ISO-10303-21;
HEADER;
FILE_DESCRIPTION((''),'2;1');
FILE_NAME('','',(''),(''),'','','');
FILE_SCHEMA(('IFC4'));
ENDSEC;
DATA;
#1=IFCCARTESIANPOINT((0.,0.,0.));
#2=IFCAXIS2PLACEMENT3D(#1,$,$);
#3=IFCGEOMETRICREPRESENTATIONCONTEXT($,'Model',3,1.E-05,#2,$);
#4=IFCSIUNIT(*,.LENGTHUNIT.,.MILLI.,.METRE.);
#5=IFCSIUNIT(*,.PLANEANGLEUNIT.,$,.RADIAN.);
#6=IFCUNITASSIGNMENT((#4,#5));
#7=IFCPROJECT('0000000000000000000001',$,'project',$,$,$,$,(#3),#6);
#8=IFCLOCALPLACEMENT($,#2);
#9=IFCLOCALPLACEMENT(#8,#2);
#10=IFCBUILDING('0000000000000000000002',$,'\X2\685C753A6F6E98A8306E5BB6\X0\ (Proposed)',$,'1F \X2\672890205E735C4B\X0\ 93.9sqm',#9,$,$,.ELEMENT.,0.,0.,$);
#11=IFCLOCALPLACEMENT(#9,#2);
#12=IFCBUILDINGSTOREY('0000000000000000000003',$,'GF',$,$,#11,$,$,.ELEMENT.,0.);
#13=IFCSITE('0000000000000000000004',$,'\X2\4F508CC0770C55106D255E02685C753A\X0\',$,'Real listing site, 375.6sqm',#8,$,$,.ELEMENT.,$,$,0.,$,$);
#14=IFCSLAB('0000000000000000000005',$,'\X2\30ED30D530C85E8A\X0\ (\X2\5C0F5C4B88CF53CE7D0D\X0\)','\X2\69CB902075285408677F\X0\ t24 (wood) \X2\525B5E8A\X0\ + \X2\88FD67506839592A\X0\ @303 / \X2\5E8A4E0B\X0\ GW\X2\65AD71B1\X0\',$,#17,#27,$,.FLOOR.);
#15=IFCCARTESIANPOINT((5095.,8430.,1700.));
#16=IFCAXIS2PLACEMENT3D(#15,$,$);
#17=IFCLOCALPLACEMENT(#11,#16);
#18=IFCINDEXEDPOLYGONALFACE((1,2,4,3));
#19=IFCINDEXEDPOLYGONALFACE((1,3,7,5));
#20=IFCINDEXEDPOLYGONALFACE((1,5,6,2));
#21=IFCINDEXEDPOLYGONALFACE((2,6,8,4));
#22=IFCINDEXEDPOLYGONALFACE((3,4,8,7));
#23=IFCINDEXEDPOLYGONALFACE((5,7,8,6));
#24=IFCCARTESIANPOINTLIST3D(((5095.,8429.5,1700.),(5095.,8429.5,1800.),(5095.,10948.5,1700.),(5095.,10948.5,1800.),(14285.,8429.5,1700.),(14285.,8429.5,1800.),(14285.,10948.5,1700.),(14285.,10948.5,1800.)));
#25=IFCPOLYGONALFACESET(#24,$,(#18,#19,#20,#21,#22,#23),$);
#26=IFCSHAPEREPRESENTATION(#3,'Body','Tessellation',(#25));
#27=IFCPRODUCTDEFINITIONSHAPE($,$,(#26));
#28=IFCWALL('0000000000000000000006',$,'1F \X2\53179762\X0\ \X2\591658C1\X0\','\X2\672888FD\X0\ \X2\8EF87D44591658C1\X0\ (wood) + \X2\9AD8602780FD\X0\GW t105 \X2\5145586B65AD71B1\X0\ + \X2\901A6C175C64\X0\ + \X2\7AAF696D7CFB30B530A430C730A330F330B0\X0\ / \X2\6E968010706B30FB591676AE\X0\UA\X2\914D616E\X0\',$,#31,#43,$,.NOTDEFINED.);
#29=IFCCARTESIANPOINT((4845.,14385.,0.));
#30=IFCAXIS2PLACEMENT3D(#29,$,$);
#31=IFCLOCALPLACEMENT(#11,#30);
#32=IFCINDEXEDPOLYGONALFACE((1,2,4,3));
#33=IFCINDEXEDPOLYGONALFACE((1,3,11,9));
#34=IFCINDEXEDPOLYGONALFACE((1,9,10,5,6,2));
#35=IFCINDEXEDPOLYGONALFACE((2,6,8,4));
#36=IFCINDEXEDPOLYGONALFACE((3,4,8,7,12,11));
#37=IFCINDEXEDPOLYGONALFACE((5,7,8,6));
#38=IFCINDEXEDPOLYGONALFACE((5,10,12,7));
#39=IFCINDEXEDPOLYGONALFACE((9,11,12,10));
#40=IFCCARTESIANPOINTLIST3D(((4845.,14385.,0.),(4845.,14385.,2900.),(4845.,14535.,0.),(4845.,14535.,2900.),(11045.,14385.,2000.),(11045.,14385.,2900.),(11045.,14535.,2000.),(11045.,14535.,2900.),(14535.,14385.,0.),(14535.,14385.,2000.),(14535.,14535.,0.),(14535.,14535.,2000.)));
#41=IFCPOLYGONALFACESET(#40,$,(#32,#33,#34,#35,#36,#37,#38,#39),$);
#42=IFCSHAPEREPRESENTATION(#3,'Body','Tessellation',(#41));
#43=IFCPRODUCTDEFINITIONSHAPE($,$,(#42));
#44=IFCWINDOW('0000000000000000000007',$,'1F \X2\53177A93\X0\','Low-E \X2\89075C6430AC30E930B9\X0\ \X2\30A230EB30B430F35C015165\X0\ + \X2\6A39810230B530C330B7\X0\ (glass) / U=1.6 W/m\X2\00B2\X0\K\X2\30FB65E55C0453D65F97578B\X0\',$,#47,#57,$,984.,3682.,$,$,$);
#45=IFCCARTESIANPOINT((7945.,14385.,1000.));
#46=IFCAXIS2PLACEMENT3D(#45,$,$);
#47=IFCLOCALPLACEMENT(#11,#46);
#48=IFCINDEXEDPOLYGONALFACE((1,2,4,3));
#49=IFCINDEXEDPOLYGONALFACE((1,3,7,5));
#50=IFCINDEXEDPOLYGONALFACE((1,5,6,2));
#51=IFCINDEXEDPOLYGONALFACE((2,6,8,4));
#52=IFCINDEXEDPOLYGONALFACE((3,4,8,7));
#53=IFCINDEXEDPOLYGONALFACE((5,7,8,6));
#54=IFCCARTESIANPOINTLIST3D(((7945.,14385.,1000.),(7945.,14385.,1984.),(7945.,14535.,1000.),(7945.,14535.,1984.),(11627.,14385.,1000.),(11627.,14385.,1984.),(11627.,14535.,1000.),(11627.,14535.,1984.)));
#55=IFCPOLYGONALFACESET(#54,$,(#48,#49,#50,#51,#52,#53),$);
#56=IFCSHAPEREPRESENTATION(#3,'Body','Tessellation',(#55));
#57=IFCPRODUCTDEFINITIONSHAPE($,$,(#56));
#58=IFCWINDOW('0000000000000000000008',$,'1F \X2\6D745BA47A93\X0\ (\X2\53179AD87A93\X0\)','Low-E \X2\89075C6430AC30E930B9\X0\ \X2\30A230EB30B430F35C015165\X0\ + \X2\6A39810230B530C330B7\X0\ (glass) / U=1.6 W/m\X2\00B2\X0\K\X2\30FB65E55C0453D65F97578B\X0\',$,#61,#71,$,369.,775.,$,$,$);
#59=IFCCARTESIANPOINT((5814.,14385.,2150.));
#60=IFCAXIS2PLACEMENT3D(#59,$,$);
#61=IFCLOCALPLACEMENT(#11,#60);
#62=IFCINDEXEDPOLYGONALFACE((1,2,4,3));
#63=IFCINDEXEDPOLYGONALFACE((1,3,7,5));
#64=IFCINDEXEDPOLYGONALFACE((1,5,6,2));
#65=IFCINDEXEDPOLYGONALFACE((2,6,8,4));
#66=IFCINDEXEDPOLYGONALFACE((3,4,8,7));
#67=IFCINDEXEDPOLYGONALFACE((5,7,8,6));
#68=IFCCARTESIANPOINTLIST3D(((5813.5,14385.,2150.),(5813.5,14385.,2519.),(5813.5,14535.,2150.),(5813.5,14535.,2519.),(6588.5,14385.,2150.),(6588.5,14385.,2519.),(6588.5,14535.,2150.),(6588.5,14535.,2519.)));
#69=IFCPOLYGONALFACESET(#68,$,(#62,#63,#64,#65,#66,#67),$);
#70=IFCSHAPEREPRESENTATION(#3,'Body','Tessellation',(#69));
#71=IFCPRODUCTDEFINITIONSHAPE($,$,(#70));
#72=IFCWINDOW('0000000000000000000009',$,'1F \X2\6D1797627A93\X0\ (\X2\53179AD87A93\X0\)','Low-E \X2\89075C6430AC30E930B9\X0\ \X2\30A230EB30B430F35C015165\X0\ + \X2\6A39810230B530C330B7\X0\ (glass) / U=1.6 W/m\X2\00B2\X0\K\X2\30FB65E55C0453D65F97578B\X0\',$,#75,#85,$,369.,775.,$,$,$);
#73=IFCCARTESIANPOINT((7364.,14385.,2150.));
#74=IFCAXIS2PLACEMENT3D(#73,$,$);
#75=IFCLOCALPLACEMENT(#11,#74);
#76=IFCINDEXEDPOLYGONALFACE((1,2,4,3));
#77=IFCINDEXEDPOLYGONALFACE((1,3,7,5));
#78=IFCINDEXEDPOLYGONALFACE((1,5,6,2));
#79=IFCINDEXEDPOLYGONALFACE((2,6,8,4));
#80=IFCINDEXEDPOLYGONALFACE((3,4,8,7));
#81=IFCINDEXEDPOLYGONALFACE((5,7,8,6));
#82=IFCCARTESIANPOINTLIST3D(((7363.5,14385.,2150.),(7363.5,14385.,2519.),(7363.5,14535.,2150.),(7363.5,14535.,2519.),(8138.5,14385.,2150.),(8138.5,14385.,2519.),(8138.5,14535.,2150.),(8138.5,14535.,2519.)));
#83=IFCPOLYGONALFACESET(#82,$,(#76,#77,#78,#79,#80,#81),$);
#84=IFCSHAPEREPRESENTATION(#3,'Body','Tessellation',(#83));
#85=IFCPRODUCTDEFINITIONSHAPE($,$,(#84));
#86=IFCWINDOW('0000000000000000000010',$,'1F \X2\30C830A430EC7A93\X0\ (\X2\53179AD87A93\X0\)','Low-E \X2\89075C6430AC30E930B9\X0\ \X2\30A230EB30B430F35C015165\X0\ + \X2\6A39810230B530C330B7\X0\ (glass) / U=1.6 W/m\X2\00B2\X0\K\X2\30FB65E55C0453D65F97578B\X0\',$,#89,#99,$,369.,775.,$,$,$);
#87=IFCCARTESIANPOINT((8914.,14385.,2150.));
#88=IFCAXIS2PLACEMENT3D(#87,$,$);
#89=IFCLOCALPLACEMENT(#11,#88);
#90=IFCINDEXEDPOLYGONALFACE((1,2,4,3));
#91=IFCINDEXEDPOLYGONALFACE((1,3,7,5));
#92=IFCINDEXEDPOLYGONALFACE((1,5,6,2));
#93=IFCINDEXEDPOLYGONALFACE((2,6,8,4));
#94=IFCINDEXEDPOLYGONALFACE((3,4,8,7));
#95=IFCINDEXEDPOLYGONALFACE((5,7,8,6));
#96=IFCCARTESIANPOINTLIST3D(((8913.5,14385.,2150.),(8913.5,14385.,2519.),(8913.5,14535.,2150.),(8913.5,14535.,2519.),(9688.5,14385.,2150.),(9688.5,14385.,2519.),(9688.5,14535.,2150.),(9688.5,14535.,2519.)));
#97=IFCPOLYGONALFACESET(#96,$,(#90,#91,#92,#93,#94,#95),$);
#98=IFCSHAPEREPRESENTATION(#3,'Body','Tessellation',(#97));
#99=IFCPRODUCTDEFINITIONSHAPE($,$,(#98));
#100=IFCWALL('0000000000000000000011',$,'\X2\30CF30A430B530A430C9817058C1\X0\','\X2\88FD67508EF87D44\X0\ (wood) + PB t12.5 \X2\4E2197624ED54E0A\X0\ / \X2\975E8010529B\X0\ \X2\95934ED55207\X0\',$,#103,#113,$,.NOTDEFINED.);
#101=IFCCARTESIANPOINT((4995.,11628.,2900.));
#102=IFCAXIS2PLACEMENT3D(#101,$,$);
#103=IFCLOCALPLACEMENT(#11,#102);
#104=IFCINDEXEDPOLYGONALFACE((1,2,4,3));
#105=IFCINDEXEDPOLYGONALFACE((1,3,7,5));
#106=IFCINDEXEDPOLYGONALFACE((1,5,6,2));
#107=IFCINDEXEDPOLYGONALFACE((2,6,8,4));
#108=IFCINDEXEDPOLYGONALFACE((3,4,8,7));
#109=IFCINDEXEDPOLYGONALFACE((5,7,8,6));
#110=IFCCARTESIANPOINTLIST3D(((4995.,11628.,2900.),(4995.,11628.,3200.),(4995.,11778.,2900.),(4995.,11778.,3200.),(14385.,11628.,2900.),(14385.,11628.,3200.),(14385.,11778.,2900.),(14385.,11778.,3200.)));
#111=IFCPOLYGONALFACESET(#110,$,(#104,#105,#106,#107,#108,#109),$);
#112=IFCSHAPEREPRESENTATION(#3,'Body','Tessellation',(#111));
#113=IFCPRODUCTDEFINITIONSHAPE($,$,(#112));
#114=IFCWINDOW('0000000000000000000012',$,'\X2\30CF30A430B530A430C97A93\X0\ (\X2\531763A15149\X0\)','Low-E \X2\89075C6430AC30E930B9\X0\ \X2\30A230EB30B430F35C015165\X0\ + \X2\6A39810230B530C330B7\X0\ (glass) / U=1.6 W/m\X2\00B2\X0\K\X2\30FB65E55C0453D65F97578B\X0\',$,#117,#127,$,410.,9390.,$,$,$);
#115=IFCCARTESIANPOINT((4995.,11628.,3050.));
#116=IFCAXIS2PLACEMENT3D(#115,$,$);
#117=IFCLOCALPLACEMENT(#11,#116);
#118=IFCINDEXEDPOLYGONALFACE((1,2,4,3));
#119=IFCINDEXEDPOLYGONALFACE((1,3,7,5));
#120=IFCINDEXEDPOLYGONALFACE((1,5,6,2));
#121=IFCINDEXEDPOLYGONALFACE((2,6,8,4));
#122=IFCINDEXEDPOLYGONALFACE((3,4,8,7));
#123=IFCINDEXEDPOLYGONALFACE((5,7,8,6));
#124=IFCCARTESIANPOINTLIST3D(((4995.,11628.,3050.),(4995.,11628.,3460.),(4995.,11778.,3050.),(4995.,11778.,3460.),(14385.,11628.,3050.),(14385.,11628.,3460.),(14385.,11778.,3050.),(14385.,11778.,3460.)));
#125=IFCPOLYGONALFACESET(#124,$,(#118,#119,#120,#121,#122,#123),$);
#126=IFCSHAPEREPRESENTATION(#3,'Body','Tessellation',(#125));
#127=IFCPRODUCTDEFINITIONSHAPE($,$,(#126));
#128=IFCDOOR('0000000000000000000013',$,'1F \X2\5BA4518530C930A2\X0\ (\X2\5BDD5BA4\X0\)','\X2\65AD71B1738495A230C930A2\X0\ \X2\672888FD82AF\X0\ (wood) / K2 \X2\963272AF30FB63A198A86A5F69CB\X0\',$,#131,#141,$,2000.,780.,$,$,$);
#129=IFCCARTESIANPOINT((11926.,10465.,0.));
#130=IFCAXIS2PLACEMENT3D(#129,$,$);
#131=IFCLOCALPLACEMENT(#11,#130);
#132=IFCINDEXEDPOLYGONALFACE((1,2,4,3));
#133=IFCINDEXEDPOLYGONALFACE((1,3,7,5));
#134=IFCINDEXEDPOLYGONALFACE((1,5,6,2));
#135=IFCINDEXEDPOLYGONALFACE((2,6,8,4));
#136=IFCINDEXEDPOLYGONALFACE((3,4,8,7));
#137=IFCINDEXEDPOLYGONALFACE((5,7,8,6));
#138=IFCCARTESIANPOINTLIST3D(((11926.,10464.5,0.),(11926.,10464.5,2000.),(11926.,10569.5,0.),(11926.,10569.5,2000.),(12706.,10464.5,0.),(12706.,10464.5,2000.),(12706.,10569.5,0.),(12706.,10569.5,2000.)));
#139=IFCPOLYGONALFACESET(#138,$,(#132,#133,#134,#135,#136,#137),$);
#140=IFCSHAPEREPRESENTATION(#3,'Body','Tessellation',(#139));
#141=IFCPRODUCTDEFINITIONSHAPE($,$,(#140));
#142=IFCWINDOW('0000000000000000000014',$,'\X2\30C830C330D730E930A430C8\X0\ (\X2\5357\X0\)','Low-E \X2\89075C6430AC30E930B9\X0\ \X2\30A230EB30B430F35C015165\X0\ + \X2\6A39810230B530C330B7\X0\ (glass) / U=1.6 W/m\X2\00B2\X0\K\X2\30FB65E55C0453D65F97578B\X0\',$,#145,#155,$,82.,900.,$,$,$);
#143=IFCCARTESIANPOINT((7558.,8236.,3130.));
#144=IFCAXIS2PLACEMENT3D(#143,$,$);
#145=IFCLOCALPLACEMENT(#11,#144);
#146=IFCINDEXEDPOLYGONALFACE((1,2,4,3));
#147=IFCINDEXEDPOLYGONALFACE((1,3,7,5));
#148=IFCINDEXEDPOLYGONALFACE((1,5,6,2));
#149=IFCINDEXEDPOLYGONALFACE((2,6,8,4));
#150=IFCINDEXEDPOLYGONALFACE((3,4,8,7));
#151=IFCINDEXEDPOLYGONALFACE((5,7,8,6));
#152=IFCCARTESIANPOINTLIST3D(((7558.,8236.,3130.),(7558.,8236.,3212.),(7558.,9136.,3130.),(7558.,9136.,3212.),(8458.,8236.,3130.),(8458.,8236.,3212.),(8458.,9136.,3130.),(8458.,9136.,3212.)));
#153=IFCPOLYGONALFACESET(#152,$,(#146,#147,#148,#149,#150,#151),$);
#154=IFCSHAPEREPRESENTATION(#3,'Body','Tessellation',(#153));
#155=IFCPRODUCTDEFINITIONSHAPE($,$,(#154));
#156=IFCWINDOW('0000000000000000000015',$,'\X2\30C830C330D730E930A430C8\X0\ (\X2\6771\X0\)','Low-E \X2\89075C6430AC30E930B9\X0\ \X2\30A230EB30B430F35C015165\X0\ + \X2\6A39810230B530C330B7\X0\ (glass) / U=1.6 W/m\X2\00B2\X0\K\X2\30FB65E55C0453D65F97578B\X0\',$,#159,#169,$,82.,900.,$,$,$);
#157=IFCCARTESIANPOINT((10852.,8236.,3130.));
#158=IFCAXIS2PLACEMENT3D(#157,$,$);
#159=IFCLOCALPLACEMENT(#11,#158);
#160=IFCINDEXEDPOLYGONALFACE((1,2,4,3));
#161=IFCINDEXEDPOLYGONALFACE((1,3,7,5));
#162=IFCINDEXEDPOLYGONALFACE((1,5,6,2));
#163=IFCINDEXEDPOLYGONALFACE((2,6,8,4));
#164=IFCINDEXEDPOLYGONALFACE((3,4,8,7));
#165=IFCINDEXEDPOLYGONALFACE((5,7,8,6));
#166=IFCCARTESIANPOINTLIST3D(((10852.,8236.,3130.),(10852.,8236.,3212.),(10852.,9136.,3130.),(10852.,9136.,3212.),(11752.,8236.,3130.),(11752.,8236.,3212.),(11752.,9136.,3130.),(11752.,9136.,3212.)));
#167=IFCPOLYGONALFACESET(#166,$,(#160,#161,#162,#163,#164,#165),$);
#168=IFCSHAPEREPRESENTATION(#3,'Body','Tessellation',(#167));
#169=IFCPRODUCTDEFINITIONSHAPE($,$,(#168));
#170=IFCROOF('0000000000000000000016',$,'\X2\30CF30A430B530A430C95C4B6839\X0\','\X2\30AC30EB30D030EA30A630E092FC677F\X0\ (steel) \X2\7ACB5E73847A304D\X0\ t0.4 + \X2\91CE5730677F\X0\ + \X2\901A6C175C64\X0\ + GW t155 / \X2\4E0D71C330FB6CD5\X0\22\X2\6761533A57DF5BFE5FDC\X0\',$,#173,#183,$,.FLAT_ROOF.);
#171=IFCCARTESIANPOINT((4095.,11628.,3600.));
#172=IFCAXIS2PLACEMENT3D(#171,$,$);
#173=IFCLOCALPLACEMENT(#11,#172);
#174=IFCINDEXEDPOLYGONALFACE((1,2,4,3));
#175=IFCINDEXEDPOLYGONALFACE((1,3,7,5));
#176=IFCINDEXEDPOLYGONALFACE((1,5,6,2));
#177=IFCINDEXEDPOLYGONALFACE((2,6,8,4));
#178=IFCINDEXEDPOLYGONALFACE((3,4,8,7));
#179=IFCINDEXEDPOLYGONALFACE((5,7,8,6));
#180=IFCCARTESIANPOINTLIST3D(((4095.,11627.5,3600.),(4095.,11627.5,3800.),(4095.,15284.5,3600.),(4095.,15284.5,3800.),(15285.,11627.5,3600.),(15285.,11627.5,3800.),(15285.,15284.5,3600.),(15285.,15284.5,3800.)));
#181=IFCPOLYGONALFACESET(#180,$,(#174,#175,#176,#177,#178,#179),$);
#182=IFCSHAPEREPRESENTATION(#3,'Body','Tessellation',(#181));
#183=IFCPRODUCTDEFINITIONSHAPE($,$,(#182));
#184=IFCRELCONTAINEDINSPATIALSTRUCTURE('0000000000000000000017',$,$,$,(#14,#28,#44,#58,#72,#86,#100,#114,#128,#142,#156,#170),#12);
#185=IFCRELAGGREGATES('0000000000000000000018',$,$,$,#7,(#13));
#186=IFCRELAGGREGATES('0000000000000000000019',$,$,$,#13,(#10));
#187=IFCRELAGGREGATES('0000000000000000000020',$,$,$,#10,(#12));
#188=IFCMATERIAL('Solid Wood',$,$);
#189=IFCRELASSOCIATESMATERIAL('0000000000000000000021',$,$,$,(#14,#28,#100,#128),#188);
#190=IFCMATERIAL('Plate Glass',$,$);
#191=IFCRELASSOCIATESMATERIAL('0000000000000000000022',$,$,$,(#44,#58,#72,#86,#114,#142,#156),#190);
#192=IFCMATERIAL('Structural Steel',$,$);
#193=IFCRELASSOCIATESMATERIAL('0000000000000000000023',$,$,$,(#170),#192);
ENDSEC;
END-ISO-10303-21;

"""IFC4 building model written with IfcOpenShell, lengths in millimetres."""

from ifc_helpers import new_model, si_unit, frame, frame_2d, origin, place, context, project, spatial, rectangle, extrude, material, element, fill, save


model = new_model("IFC4")

# Units and contexts
model_context = context("Model", 3, precision=1e-05, world=origin())
ifc_project = project(units=[si_unit("LENGTHUNIT", "METRE", prefix="MILLI"), si_unit("PLANEANGLEUNIT", "RADIAN")], contexts=[model_context])

# Site, building, storey
site_placement = place(None, origin())
site = spatial("IfcSite", under=ifc_project, at=site_placement, Name="佐賀県唐津市桜町", ObjectType="Real listing site, 375.6sqm", CompositionType="ELEMENT", RefElevation=0.0)
building_placement = place(site_placement, origin())
building = spatial("IfcBuilding", under=site, at=building_placement, Name="桜町潮風の家 (Proposed)", ObjectType="1F 木造平屋 93.9sqm", CompositionType="ELEMENT", ElevationOfRefHeight=0.0, ElevationOfTerrain=0.0)
storey_placement = place(building_placement, origin())
storey = spatial("IfcBuildingStorey", under=building, at=storey_placement, Name="GF", CompositionType="ELEMENT", Elevation=0.0)

# Slab
ifc_material_1 = material(Name="Solid Wood")
slab_placement = place(storey_placement, frame((5095.0, 8430.0, 1700.0)))
element("IfcSlab", 1, at=slab_placement, inside=storey, material=ifc_material_1, Name="ロフト床 (小屋裏収納)", Description="構造用合板 t24 (wood) 剛床 + 製材根太 @303 / 床下 GW断熱", PredefinedType="FLOOR", context=model_context, shape_type="SweptSolid", body=[
    extrude(rectangle(XDim=9190.0, YDim=2519.0, at=frame_2d((4595.0, 1259.0))), frame((5095.0, 8430.0, 1700.0)), (0.0, 0.0, 1.0), 100.0),
])

# Wall, openings, windows
wall_1_placement = place(storey_placement, frame((4845.0, 14385.0, 0.0)))
wall_1 = element("IfcWall", 2, at=wall_1_placement, inside=storey, material=ifc_material_1, Name="1F 北面 外壁", Description="木製 軸組外壁 (wood) + 高性能GW t105 充填断熱 + 通気層 + 窯業系サイディング / 準耐火・外皮UA配慮", PredefinedType="NOTDEFINED", context=model_context, shape_type="SweptSolid", body=[
    extrude(rectangle(XDim=9690.0, YDim=150.0, at=frame_2d((4845.0, 75.0))), frame((4845.0, 14385.0, 0.0)), (0.0, 0.0, 1.0), 2900.0),
])
opening_1_placement = place(storey_placement, frame((7945.0, 14385.0, 1000.0)))
opening_1 = element("IfcOpeningElement", 3, at=opening_1_placement, cuts=wall_1, PredefinedType="NOTDEFINED", context=model_context, shape_type="SweptSolid", body=[
    extrude(rectangle(XDim=3682.0, YDim=150.0, at=frame_2d((1841.0, 75.0))), frame((7945.0, 14385.0, 1000.0)), (0.0, 0.0, 1.0), 984.0),
])
opening_2_placement = place(storey_placement, frame((5814.0, 14385.0, 2150.0)))
opening_2 = element("IfcOpeningElement", 4, at=opening_2_placement, cuts=wall_1, PredefinedType="NOTDEFINED", context=model_context, shape_type="SweptSolid", body=[
    extrude(rectangle(XDim=775.0, YDim=150.0, at=frame_2d((387.0, 75.0))), frame((5814.0, 14385.0, 2150.0)), (0.0, 0.0, 1.0), 369.0),
])
opening_3_placement = place(storey_placement, frame((7364.0, 14385.0, 2150.0)))
opening_3 = element("IfcOpeningElement", 5, at=opening_3_placement, cuts=wall_1, PredefinedType="NOTDEFINED", context=model_context, shape_type="SweptSolid", body=[
    extrude(rectangle(XDim=775.0, YDim=150.0, at=frame_2d((387.0, 75.0))), frame((7364.0, 14385.0, 2150.0)), (0.0, 0.0, 1.0), 369.0),
])
opening_4_placement = place(storey_placement, frame((8914.0, 14385.0, 2150.0)))
opening_4 = element("IfcOpeningElement", 6, at=opening_4_placement, cuts=wall_1, PredefinedType="NOTDEFINED", context=model_context, shape_type="SweptSolid", body=[
    extrude(rectangle(XDim=775.0, YDim=150.0, at=frame_2d((387.0, 75.0))), frame((8914.0, 14385.0, 2150.0)), (0.0, 0.0, 1.0), 369.0),
])
ifc_material_2 = material(Name="Plate Glass")
window_1_placement = place(storey_placement, frame((7945.0, 14385.0, 1000.0)))
window_1 = element("IfcWindow", 7, at=window_1_placement, inside=storey, material=ifc_material_2, Name="1F 北窓", Description="Low-E 複層ガラス アルゴン封入 + 樹脂サッシ (glass) / U=1.6 W/m²K・日射取得型", OverallHeight=984.0, OverallWidth=3682.0, context=model_context, shape_type="SweptSolid", body=[
    extrude(rectangle(XDim=3682.0, YDim=150.0, at=frame_2d((1841.0, 75.0))), frame((7945.0, 14385.0, 1000.0)), (0.0, 0.0, 1.0), 984.0),
])
fill(opening_1, window_1)
window_2_placement = place(storey_placement, frame((5814.0, 14385.0, 2150.0)))
window_2 = element("IfcWindow", 8, at=window_2_placement, inside=storey, material=ifc_material_2, Name="1F 浴室窓 (北高窓)", Description="Low-E 複層ガラス アルゴン封入 + 樹脂サッシ (glass) / U=1.6 W/m²K・日射取得型", OverallHeight=369.0, OverallWidth=775.0, context=model_context, shape_type="SweptSolid", body=[
    extrude(rectangle(XDim=775.0, YDim=150.0, at=frame_2d((387.0, 75.0))), frame((5814.0, 14385.0, 2150.0)), (0.0, 0.0, 1.0), 369.0),
])
fill(opening_2, window_2)
window_3_placement = place(storey_placement, frame((7364.0, 14385.0, 2150.0)))
window_3 = element("IfcWindow", 9, at=window_3_placement, inside=storey, material=ifc_material_2, Name="1F 洗面窓 (北高窓)", Description="Low-E 複層ガラス アルゴン封入 + 樹脂サッシ (glass) / U=1.6 W/m²K・日射取得型", OverallHeight=369.0, OverallWidth=775.0, context=model_context, shape_type="SweptSolid", body=[
    extrude(rectangle(XDim=775.0, YDim=150.0, at=frame_2d((387.0, 75.0))), frame((7364.0, 14385.0, 2150.0)), (0.0, 0.0, 1.0), 369.0),
])
fill(opening_3, window_3)
window_4_placement = place(storey_placement, frame((8914.0, 14385.0, 2150.0)))
window_4 = element("IfcWindow", 10, at=window_4_placement, inside=storey, material=ifc_material_2, Name="1F トイレ窓 (北高窓)", Description="Low-E 複層ガラス アルゴン封入 + 樹脂サッシ (glass) / U=1.6 W/m²K・日射取得型", OverallHeight=369.0, OverallWidth=775.0, context=model_context, shape_type="SweptSolid", body=[
    extrude(rectangle(XDim=775.0, YDim=150.0, at=frame_2d((387.0, 75.0))), frame((8914.0, 14385.0, 2150.0)), (0.0, 0.0, 1.0), 369.0),
])
fill(opening_4, window_4)

# Wall, opening, window
wall_2_placement = place(storey_placement, frame((4995.0, 11628.0, 2900.0)))
wall_2 = element("IfcWall", 11, at=wall_2_placement, inside=storey, material=ifc_material_1, Name="ハイサイド腰壁", Description="製材軸組 (wood) + PB t12.5 両面仕上 / 非耐力 間仕切", PredefinedType="NOTDEFINED", context=model_context, shape_type="SweptSolid", body=[
    extrude(rectangle(XDim=9390.0, YDim=150.0, at=frame_2d((4695.0, 75.0))), frame((4995.0, 11628.0, 2900.0)), (0.0, 0.0, 1.0), 700.0),
])
opening_5_placement = place(storey_placement, frame((4995.0, 11628.0, 3050.0)))
opening_5 = element("IfcOpeningElement", 12, at=opening_5_placement, cuts=wall_2, PredefinedType="NOTDEFINED", context=model_context, shape_type="SweptSolid", body=[
    extrude(rectangle(XDim=9390.0, YDim=150.0, at=frame_2d((4695.0, 75.0))), frame((4995.0, 11628.0, 3050.0)), (0.0, 0.0, 1.0), 410.0),
])
window_5_placement = place(storey_placement, frame((4995.0, 11628.0, 3050.0)))
window_5 = element("IfcWindow", 13, at=window_5_placement, inside=storey, material=ifc_material_2, Name="ハイサイド窓 (北採光)", Description="Low-E 複層ガラス アルゴン封入 + 樹脂サッシ (glass) / U=1.6 W/m²K・日射取得型", OverallHeight=410.0, OverallWidth=9390.0, context=model_context, shape_type="SweptSolid", body=[
    extrude(rectangle(XDim=9390.0, YDim=150.0, at=frame_2d((4695.0, 75.0))), frame((4995.0, 11628.0, 3050.0)), (0.0, 0.0, 1.0), 410.0),
])
fill(opening_5, window_5)

# Door
door_1_placement = place(storey_placement, frame((11926.0, 10465.0, 0.0)))
element("IfcDoor", 14, at=door_1_placement, inside=storey, material=ifc_material_1, Name="1F 室内ドア (寝室)", Description="断熱玄関ドア 木製芯 (wood) / K2 防犯・採風機構", OverallHeight=2000.0, OverallWidth=780.0, context=model_context, shape_type="SweptSolid", body=[
    extrude(rectangle(XDim=780.0, YDim=105.0, at=frame_2d((390.0, 52.0))), frame((11926.0, 10465.0, 0.0)), (0.0, 0.0, 1.0), 2000.0),
])

# Windows
window_6_placement = place(storey_placement, frame((7558.0, 8236.0, 3130.0)))
element("IfcWindow", 15, at=window_6_placement, inside=storey, material=ifc_material_2, Name="トップライト (南)", Description="Low-E 複層ガラス アルゴン封入 + 樹脂サッシ (glass) / U=1.6 W/m²K・日射取得型", OverallHeight=82.0, OverallWidth=900.0, context=model_context, shape_type="SweptSolid", body=[
    extrude(rectangle(XDim=900.0, YDim=900.0, at=frame_2d((450.0, 450.0))), frame((7558.0, 8236.0, 3130.0)), (0.0, 0.0, 1.0), 82.0),
])
window_7_placement = place(storey_placement, frame((10852.0, 8236.0, 3130.0)))
element("IfcWindow", 16, at=window_7_placement, inside=storey, material=ifc_material_2, Name="トップライト (東)", Description="Low-E 複層ガラス アルゴン封入 + 樹脂サッシ (glass) / U=1.6 W/m²K・日射取得型", OverallHeight=82.0, OverallWidth=900.0, context=model_context, shape_type="SweptSolid", body=[
    extrude(rectangle(XDim=900.0, YDim=900.0, at=frame_2d((450.0, 450.0))), frame((10852.0, 8236.0, 3130.0)), (0.0, 0.0, 1.0), 82.0),
])

# Roof
ifc_material_3 = material(Name="Structural Steel")
roof_placement = place(storey_placement, frame((4095.0, 11628.0, 3600.0)))
element("IfcRoof", 17, at=roof_placement, inside=storey, material=ifc_material_3, Name="ハイサイド屋根", Description="ガルバリウム鋼板 (steel) 立平葺き t0.4 + 野地板 + 通気層 + GW t155 / 不燃・法22条区域対応", PredefinedType="FLAT_ROOF", context=model_context, shape_type="SweptSolid", body=[
    extrude(rectangle(XDim=11190.0, YDim=3657.0, at=frame_2d((5595.0, 1828.0))), frame((4095.0, 11628.0, 3600.0)), (0.0, 0.0, 1.0), 200.0),
])

save(model, "model.ifc")
